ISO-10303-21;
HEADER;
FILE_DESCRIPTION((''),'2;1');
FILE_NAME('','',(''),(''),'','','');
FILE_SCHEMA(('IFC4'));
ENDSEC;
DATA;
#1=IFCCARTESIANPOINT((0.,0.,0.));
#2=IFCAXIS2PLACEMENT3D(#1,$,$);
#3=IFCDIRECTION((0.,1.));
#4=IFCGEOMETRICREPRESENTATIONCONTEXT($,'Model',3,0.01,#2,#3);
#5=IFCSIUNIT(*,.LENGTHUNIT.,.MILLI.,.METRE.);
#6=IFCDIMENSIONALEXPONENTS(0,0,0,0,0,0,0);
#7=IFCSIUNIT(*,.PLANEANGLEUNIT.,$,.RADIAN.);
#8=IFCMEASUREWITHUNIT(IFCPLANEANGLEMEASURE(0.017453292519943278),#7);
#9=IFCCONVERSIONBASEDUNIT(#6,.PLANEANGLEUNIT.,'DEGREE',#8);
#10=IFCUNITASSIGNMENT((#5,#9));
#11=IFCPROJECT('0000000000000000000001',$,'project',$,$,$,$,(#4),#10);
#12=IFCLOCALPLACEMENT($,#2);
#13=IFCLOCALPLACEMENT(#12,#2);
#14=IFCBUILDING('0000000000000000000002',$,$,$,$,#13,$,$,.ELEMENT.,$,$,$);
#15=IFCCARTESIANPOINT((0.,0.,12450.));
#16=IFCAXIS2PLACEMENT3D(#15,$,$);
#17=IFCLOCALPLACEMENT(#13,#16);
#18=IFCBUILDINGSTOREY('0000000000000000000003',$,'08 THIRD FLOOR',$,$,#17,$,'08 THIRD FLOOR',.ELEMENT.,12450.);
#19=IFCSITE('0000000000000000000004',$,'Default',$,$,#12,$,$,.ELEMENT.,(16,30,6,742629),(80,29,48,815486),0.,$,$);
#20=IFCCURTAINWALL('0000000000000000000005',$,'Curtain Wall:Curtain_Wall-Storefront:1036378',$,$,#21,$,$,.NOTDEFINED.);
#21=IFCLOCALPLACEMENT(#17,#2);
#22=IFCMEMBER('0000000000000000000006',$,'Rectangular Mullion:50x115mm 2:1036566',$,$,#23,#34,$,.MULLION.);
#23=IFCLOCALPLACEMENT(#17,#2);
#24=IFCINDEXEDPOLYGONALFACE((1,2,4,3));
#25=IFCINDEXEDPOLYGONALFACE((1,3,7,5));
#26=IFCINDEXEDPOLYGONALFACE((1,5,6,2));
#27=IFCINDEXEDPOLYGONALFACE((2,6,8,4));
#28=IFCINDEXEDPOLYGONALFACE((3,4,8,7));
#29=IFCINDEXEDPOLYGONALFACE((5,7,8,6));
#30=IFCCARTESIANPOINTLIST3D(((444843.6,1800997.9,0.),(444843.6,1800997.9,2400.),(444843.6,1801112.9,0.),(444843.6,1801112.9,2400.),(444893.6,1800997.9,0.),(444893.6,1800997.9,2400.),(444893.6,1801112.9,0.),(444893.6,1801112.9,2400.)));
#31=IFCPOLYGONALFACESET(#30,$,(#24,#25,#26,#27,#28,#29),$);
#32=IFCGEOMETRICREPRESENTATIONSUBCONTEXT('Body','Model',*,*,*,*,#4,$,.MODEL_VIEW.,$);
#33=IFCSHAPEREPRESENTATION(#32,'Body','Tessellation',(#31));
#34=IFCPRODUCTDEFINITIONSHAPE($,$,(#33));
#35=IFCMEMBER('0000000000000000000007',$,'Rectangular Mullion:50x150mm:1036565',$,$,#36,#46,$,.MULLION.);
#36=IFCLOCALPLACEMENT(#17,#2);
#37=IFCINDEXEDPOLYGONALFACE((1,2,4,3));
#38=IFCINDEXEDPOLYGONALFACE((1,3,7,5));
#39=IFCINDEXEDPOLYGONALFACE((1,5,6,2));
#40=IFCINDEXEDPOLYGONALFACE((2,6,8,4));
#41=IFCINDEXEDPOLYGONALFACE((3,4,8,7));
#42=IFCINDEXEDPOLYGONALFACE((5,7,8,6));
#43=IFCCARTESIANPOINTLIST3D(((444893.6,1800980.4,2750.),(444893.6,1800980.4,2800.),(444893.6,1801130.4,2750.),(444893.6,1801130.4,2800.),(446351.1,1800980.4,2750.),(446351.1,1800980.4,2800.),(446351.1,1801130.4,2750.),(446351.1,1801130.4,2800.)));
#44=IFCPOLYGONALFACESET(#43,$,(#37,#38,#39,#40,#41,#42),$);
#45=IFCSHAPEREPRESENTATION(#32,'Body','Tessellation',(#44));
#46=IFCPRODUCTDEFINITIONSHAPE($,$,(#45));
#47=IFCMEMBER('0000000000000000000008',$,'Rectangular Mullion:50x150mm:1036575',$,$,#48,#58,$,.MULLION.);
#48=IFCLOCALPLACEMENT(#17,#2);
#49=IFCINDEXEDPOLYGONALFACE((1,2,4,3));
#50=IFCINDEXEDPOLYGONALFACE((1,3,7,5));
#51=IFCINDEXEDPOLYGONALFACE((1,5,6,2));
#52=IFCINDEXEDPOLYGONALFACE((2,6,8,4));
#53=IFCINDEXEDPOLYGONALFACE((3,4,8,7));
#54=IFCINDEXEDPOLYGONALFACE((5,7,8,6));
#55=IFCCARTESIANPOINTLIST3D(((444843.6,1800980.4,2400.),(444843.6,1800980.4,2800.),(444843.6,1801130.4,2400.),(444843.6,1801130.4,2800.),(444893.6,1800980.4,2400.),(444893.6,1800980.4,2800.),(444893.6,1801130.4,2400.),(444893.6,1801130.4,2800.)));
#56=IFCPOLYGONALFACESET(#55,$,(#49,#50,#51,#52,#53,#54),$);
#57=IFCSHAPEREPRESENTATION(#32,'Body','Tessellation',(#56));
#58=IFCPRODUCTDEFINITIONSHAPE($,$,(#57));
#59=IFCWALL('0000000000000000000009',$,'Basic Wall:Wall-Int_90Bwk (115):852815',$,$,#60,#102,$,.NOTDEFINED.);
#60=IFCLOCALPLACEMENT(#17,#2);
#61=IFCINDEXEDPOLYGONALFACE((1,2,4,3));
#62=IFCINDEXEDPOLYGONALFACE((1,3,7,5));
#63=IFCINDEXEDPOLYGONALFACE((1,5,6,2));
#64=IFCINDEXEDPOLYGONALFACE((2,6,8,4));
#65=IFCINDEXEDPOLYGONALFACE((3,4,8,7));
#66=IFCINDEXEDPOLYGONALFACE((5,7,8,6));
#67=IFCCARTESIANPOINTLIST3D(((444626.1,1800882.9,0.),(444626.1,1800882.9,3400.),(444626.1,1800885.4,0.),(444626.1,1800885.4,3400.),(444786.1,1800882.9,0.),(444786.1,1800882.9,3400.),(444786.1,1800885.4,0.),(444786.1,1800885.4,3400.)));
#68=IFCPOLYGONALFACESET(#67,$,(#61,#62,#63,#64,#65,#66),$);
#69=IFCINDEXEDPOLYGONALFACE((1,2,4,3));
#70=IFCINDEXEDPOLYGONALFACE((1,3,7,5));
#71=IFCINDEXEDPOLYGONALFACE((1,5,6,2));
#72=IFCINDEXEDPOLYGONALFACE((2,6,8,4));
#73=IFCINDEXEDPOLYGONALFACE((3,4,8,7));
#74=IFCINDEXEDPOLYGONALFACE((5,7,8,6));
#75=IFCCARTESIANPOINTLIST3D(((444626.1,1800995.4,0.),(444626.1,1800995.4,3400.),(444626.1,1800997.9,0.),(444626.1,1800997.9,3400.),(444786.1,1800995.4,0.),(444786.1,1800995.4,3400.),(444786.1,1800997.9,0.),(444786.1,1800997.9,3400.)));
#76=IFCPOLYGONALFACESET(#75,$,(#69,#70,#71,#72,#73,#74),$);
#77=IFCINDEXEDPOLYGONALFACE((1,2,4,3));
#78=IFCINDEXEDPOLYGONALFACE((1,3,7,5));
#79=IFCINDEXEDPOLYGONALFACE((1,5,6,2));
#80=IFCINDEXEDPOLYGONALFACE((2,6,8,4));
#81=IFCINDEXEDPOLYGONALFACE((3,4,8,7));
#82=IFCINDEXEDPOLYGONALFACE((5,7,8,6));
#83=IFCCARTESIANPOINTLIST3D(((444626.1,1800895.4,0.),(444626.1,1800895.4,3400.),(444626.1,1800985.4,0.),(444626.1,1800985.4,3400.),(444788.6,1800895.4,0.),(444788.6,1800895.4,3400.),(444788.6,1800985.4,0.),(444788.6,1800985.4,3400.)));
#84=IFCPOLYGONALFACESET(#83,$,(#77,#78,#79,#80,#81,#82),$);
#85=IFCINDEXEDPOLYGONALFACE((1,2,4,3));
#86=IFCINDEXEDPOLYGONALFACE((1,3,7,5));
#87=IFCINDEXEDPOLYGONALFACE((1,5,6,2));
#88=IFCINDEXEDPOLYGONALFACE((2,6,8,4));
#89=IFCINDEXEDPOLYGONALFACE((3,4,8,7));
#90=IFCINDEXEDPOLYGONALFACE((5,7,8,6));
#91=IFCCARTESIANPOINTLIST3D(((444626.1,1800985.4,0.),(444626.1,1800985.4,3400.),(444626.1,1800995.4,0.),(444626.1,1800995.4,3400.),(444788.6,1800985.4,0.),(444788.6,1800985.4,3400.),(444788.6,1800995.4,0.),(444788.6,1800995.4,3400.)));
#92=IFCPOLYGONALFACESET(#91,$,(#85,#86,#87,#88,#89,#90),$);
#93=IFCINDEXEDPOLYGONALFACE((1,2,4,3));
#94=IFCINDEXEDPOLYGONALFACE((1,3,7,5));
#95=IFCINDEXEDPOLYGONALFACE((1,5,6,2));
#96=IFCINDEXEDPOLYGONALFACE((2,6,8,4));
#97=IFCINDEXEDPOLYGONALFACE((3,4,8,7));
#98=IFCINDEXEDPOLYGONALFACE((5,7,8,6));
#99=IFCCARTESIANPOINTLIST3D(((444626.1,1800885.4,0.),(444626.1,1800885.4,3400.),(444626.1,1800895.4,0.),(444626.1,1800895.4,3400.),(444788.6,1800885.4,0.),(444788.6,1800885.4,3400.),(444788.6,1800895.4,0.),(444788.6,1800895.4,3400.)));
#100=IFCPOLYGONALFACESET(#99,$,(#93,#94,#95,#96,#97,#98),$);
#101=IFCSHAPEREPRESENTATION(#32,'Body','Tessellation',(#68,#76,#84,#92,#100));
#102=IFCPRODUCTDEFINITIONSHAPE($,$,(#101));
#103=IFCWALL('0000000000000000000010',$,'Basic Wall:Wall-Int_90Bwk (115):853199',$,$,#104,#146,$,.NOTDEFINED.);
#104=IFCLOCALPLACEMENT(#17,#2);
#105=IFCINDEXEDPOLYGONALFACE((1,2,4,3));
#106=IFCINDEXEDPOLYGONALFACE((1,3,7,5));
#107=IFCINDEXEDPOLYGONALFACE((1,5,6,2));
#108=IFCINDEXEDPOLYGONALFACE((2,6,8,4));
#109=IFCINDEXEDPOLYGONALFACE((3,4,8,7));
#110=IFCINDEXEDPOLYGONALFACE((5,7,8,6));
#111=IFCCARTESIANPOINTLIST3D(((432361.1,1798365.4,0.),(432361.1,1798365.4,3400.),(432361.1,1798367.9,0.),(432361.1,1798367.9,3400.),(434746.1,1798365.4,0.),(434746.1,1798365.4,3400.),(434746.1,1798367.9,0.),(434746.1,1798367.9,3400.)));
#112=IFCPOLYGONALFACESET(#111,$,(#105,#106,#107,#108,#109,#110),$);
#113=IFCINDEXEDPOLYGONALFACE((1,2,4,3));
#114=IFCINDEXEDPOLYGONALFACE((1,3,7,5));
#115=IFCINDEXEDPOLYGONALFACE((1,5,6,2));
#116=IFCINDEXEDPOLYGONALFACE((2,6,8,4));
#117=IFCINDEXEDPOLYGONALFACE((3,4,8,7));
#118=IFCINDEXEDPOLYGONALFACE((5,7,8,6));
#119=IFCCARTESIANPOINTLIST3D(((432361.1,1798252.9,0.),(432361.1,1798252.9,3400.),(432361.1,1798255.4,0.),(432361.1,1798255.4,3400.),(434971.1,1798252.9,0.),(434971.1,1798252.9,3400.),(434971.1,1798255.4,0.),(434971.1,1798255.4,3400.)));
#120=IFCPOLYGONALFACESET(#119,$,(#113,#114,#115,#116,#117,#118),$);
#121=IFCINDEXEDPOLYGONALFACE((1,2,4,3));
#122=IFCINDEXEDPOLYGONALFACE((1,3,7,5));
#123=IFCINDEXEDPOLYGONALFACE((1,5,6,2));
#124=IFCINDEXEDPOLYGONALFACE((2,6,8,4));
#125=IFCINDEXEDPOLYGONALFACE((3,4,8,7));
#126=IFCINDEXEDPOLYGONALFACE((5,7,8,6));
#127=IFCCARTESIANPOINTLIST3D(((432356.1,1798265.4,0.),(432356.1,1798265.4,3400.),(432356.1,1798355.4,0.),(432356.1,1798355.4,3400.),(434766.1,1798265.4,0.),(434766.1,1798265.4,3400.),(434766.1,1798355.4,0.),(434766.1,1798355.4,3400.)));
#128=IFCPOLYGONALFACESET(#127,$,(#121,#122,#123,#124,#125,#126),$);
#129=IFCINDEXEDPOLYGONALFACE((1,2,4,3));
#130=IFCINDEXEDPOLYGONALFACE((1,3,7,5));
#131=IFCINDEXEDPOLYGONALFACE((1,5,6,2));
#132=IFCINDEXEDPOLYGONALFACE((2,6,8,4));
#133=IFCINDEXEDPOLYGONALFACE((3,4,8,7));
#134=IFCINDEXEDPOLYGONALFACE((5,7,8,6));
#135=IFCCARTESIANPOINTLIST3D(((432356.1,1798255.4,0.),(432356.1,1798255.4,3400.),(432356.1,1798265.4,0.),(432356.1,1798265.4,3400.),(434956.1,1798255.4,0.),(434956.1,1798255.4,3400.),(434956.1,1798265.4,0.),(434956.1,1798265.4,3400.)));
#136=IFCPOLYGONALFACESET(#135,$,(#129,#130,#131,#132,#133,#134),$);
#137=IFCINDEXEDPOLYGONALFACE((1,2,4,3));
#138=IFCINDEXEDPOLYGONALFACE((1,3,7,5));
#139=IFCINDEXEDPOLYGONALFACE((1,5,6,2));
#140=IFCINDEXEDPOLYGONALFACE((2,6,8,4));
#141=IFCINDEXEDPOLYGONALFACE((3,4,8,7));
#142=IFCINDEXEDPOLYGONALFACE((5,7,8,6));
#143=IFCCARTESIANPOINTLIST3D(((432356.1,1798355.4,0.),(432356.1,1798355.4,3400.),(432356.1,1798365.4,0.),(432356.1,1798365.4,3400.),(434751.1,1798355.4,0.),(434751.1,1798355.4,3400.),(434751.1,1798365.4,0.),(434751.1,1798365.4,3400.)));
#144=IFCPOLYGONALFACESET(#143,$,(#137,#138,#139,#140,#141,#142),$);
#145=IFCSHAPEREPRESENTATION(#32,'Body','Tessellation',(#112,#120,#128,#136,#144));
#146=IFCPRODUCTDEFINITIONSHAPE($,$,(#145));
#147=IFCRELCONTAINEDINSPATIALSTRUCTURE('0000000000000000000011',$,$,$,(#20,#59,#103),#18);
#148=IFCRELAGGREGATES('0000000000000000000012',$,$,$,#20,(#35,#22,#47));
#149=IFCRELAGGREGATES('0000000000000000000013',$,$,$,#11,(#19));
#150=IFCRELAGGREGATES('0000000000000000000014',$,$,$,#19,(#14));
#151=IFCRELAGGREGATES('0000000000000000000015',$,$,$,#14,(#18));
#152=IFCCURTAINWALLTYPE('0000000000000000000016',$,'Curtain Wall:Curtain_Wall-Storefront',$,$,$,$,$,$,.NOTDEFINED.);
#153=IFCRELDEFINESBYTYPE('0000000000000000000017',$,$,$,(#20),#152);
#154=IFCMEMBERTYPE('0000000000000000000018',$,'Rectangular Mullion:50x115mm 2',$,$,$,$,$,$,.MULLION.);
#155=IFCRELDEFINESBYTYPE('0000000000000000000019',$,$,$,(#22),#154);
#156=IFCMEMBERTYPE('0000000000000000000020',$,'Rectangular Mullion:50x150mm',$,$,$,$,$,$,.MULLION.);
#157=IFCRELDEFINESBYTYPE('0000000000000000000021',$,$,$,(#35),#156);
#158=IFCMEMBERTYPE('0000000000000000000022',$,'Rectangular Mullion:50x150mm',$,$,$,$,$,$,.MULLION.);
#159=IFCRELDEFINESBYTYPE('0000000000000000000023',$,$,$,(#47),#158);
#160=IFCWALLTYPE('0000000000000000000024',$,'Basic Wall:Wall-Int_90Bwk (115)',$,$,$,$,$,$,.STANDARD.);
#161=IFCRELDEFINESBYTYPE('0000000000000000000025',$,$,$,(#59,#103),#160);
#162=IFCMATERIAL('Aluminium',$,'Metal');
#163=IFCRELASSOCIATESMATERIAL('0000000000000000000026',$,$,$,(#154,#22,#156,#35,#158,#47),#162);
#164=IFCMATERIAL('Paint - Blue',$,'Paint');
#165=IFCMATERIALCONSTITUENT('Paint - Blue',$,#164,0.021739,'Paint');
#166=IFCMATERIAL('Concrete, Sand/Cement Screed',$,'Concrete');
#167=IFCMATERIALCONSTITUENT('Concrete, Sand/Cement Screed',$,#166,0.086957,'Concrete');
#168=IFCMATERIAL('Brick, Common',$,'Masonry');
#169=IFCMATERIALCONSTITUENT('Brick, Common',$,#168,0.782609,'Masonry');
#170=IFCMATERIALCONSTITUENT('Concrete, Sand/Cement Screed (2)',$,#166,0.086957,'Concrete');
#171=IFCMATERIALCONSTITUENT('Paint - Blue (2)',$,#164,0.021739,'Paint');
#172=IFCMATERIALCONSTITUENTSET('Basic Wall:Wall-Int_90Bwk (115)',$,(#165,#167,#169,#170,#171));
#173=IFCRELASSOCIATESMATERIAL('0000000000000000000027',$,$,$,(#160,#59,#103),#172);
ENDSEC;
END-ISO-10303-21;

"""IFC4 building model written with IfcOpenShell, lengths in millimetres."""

from ifc_helpers import new_model, entity, si_unit, converted_unit, direction, frame, origin, place, context, subcontext, project, spatial, indexed_curve, outline, extrude, source, transform, mapped, material, constituent, constituent_set, type_object, type_shapes, element, aggregate, save


model = new_model("IFC4")

# Units and contexts
model_context = context("Model", 3, precision=0.01, world=origin(), true_north=direction((0.0, 1.0)))
body_context = subcontext(model_context, "Body", "Model", "MODEL_VIEW")
ifc_project = project(units=[si_unit("LENGTHUNIT", "METRE", prefix="MILLI"), converted_unit("PLANEANGLEUNIT", "DEGREE", entity("IfcPlaneAngleMeasure", 0.017453292519943278), si_unit("PLANEANGLEUNIT", "RADIAN"), dimensions=[0, 0, 0, 0, 0, 0, 0])], contexts=[model_context])

# Site, building, storey
site_placement = place(None, origin())
site = spatial("IfcSite", under=ifc_project, at=site_placement, Name="Default", CompositionType="ELEMENT", RefLatitude=(16, 30, 6, 742629), RefLongitude=(80, 29, 48, 815486), RefElevation=0.0)
building_placement = place(site_placement, origin())
building = spatial("IfcBuilding", under=site, at=building_placement, CompositionType="ELEMENT")
storey_placement = place(building_placement, frame((0.0, 0.0, 12450.0)))
storey = spatial("IfcBuildingStorey", under=building, at=storey_placement, Name="08 THIRD FLOOR", LongName="08 THIRD FLOOR", CompositionType="ELEMENT", Elevation=12450.0)

# Curtain wall, members
curtain_wall_type = type_object("IfcCurtainWallType", Name="Curtain Wall:Curtain_Wall-Storefront", PredefinedType="NOTDEFINED")
curtain_wall_placement = place(storey_placement, frame((0.0, 0.0, -12450.0)))
curtain_wall = element("IfcCurtainWall", 1, at=curtain_wall_placement, inside=storey, type_object=curtain_wall_type, Name="Curtain Wall:Curtain_Wall-Storefront:1036378", PredefinedType="NOTDEFINED")
ifc_material_1 = material(Name="Aluminium", Category="Metal")
member_type_1 = type_object("IfcMemberType", Name="Rectangular Mullion:50x115mm 2", PredefinedType="MULLION", material=ifc_material_1)
shared_shape_1 = source(origin(), body_context, "Body", "SweptSolid", [
    extrude(outline(indexed_curve([(-25.0, -57.5), (25.0, -57.5), (25.0, 57.5), (-25.0, 57.5), (-25.0, -57.5)], self_intersect=False)), frame((-25.0, 0.0, -2400.0), z_axis=(0.0, 0.0, 1.0), x_axis=(-1.0, 0.0, 0.0)), (0.0, 0.0, 1.0), 2400.0),
])
type_shapes(member_type_1, [shared_shape_1])
member_1_placement = place(curtain_wall_placement, frame((444843.6, 1801055.4, 12450.0), z_axis=(0.0, 0.0, -1.0), x_axis=(-1.0, 0.0, 0.0)))
member_1 = element("IfcMember", 2, at=member_1_placement, type_object=member_type_1, material=ifc_material_1, Name="Rectangular Mullion:50x115mm 2:1036566", PredefinedType="MULLION", context=body_context, shape_type="MappedRepresentation", body=[
    mapped(shared_shape_1, transform((0.0, 0.0, 0.0), scale=1.0)),
])
member_type_2 = type_object("IfcMemberType", Name="Rectangular Mullion:50x150mm", PredefinedType="MULLION", material=ifc_material_1)
shared_shape_2 = source(origin(), body_context, "Body", "SweptSolid", [
    extrude(outline(indexed_curve([(-25.0, -75.0), (25.0, -75.0), (25.0, 75.0), (-25.0, 75.0), (-25.0, -75.0)], self_intersect=False)), frame((-25.0, 0.0, -1457.5), z_axis=(0.0, 0.0, 1.0), x_axis=(-1.0, 0.0, 0.0)), (0.0, 0.0, 1.0), 1457.5),
])
type_shapes(member_type_2, [shared_shape_2])
member_2_placement = place(curtain_wall_placement, frame((444893.6, 1801055.4, 15250.0), z_axis=(-1.0, 0.0, 0.0), x_axis=(0.0, 0.0, 1.0)))
member_2 = element("IfcMember", 3, at=member_2_placement, type_object=member_type_2, material=ifc_material_1, Name="Rectangular Mullion:50x150mm:1036565", PredefinedType="MULLION", context=body_context, shape_type="MappedRepresentation", body=[
    mapped(shared_shape_2, transform((0.0, 0.0, 0.0), scale=1.0)),
])
member_type_3 = type_object("IfcMemberType", Name="Rectangular Mullion:50x150mm", PredefinedType="MULLION", material=ifc_material_1)
shared_shape_3 = source(origin(), body_context, "Body", "SweptSolid", [
    extrude(outline(indexed_curve([(-25.0, -75.0), (25.0, -75.0), (25.0, 75.0), (-25.0, 75.0), (-25.0, -75.0)], self_intersect=False)), frame((-25.0, 0.0, -400.0), z_axis=(0.0, 0.0, 1.0), x_axis=(-1.0, 0.0, 0.0)), (0.0, 0.0, 1.0), 400.0),
])
type_shapes(member_type_3, [shared_shape_3])
member_3_placement = place(curtain_wall_placement, frame((444843.6, 1801055.4, 14850.0), z_axis=(0.0, 0.0, -1.0), x_axis=(-1.0, 0.0, 0.0)))
member_3 = element("IfcMember", 4, at=member_3_placement, type_object=member_type_3, material=ifc_material_1, Name="Rectangular Mullion:50x150mm:1036575", PredefinedType="MULLION", context=body_context, shape_type="MappedRepresentation", body=[
    mapped(shared_shape_3, transform((0.0, 0.0, 0.0), scale=1.0)),
])
aggregate(curtain_wall, [member_2, member_1, member_3])

# Shared definitions
ifc_material_2 = material(Name="Paint - Blue", Category="Paint")
ifc_constituent_1 = constituent(ifc_material_2, Name="Paint - Blue", Category="Paint", fraction=0.021739)
ifc_material_3 = material(Name="Concrete, Sand/Cement Screed", Category="Concrete")
ifc_constituent_2 = constituent(ifc_material_3, Name="Concrete, Sand/Cement Screed", Category="Concrete", fraction=0.086957)
ifc_material_4 = material(Name="Brick, Common", Category="Masonry")
ifc_constituent_3 = constituent(ifc_material_4, Name="Brick, Common", Category="Masonry", fraction=0.782609)
ifc_constituent_4 = constituent(ifc_material_3, Name="Concrete, Sand/Cement Screed (2)", Category="Concrete", fraction=0.086957)
ifc_constituent_5 = constituent(ifc_material_2, Name="Paint - Blue (2)", Category="Paint", fraction=0.021739)
ifc_constituent_set_1 = constituent_set(constituents=[ifc_constituent_1, ifc_constituent_2, ifc_constituent_3, ifc_constituent_4, ifc_constituent_5], Name="Basic Wall:Wall-Int_90Bwk (115)")
wall_type_1 = type_object("IfcWallType", Name="Basic Wall:Wall-Int_90Bwk (115)", PredefinedType="STANDARD", material=ifc_constituent_set_1)

# Walls
wall_1_placement = place(storey_placement, frame((444626.1, 1800940.4, 0.0)))
element("IfcWall", 5, at=wall_1_placement, inside=storey, type_object=wall_type_1, material=ifc_constituent_set_1, Name="Basic Wall:Wall-Int_90Bwk (115):852815", PredefinedType="NOTDEFINED", context=body_context, shape_type="SweptSolid", body=[
    extrude(outline(indexed_curve([(-1.2, -80.0), (1.3, -80.0), (1.3, 80.0), (-1.2, 80.0), (-1.2, -80.0)], self_intersect=False)), frame((80.0, -56.3, 0.0), z_axis=(0.0, 0.0, 1.0), x_axis=(0.0, 1.0, 0.0)), (0.0, 0.0, 1.0), 3400.0),
    extrude(outline(indexed_curve([(-1.3, -80.0), (1.3, -80.0), (1.3, 80.0), (-1.3, 80.0), (-1.3, -80.0)], self_intersect=False)), frame((80.0, 56.3, 0.0), z_axis=(0.0, 0.0, 1.0), x_axis=(0.0, -1.0, 0.0)), (0.0, 0.0, 1.0), 3400.0),
    extrude(outline(indexed_curve([(-81.3, -45.0), (81.2, -45.0), (81.2, 45.0), (-81.3, 45.0), (-81.3, -45.0)], self_intersect=False)), frame((81.3, 0.0, 0.0)), (0.0, 0.0, 1.0), 3400.0),
    extrude(outline(indexed_curve([(-81.3, -5.0), (81.2, -5.0), (81.2, 5.0), (-81.3, 5.0), (-81.3, -5.0)], self_intersect=False)), frame((81.3, 50.0, 0.0)), (0.0, 0.0, 1.0), 3400.0),
    extrude(outline(indexed_curve([(-81.3, -5.0), (81.2, -5.0), (81.2, 5.0), (-81.3, 5.0), (-81.3, -5.0)], self_intersect=False)), frame((81.3, -50.0, 0.0)), (0.0, 0.0, 1.0), 3400.0),
])
wall_2_placement = place(storey_placement, frame((432361.1, 1798310.4, 0.0)))
element("IfcWall", 6, at=wall_2_placement, inside=storey, type_object=wall_type_1, material=ifc_constituent_set_1, Name="Basic Wall:Wall-Int_90Bwk (115):853199", PredefinedType="NOTDEFINED", context=body_context, shape_type="SweptSolid", body=[
    extrude(outline(indexed_curve([(-1.3, -1192.5), (1.3, -1192.5), (1.3, 1192.5), (-1.3, 1192.5), (-1.3, -1192.5)], self_intersect=False)), frame((1192.5, 56.3, 0.0), z_axis=(0.0, 0.0, 1.0), x_axis=(0.0, -1.0, 0.0)), (0.0, 0.0, 1.0), 3400.0),
    extrude(outline(indexed_curve([(-1.2, -1305.0), (1.3, -1305.0), (1.3, 1305.0), (-1.2, 1305.0), (-1.2, -1305.0)], self_intersect=False)), frame((1305.0, -56.3, 0.0), z_axis=(0.0, 0.0, 1.0), x_axis=(0.0, 1.0, 0.0)), (0.0, 0.0, 1.0), 3400.0),
    extrude(outline(indexed_curve([(-1205.0, -45.0), (1205.0, -45.0), (1205.0, 45.0), (-1205.0, 45.0), (-1205.0, -45.0)], self_intersect=False)), frame((1200.0, 0.0, 0.0)), (0.0, 0.0, 1.0), 3400.0),
    extrude(outline(indexed_curve([(-1300.0, -5.0), (1300.0, -5.0), (1300.0, 5.0), (-1300.0, 5.0), (-1300.0, -5.0)], self_intersect=False)), frame((1295.0, -50.0, 0.0)), (0.0, 0.0, 1.0), 3400.0),
    extrude(outline(indexed_curve([(-1197.5, -5.0), (1197.5, -5.0), (1197.5, 5.0), (-1197.5, 5.0), (-1197.5, -5.0)], self_intersect=False)), frame((1192.5, 50.0, 0.0)), (0.0, 0.0, 1.0), 3400.0),
])

save(model, "model.ifc")
